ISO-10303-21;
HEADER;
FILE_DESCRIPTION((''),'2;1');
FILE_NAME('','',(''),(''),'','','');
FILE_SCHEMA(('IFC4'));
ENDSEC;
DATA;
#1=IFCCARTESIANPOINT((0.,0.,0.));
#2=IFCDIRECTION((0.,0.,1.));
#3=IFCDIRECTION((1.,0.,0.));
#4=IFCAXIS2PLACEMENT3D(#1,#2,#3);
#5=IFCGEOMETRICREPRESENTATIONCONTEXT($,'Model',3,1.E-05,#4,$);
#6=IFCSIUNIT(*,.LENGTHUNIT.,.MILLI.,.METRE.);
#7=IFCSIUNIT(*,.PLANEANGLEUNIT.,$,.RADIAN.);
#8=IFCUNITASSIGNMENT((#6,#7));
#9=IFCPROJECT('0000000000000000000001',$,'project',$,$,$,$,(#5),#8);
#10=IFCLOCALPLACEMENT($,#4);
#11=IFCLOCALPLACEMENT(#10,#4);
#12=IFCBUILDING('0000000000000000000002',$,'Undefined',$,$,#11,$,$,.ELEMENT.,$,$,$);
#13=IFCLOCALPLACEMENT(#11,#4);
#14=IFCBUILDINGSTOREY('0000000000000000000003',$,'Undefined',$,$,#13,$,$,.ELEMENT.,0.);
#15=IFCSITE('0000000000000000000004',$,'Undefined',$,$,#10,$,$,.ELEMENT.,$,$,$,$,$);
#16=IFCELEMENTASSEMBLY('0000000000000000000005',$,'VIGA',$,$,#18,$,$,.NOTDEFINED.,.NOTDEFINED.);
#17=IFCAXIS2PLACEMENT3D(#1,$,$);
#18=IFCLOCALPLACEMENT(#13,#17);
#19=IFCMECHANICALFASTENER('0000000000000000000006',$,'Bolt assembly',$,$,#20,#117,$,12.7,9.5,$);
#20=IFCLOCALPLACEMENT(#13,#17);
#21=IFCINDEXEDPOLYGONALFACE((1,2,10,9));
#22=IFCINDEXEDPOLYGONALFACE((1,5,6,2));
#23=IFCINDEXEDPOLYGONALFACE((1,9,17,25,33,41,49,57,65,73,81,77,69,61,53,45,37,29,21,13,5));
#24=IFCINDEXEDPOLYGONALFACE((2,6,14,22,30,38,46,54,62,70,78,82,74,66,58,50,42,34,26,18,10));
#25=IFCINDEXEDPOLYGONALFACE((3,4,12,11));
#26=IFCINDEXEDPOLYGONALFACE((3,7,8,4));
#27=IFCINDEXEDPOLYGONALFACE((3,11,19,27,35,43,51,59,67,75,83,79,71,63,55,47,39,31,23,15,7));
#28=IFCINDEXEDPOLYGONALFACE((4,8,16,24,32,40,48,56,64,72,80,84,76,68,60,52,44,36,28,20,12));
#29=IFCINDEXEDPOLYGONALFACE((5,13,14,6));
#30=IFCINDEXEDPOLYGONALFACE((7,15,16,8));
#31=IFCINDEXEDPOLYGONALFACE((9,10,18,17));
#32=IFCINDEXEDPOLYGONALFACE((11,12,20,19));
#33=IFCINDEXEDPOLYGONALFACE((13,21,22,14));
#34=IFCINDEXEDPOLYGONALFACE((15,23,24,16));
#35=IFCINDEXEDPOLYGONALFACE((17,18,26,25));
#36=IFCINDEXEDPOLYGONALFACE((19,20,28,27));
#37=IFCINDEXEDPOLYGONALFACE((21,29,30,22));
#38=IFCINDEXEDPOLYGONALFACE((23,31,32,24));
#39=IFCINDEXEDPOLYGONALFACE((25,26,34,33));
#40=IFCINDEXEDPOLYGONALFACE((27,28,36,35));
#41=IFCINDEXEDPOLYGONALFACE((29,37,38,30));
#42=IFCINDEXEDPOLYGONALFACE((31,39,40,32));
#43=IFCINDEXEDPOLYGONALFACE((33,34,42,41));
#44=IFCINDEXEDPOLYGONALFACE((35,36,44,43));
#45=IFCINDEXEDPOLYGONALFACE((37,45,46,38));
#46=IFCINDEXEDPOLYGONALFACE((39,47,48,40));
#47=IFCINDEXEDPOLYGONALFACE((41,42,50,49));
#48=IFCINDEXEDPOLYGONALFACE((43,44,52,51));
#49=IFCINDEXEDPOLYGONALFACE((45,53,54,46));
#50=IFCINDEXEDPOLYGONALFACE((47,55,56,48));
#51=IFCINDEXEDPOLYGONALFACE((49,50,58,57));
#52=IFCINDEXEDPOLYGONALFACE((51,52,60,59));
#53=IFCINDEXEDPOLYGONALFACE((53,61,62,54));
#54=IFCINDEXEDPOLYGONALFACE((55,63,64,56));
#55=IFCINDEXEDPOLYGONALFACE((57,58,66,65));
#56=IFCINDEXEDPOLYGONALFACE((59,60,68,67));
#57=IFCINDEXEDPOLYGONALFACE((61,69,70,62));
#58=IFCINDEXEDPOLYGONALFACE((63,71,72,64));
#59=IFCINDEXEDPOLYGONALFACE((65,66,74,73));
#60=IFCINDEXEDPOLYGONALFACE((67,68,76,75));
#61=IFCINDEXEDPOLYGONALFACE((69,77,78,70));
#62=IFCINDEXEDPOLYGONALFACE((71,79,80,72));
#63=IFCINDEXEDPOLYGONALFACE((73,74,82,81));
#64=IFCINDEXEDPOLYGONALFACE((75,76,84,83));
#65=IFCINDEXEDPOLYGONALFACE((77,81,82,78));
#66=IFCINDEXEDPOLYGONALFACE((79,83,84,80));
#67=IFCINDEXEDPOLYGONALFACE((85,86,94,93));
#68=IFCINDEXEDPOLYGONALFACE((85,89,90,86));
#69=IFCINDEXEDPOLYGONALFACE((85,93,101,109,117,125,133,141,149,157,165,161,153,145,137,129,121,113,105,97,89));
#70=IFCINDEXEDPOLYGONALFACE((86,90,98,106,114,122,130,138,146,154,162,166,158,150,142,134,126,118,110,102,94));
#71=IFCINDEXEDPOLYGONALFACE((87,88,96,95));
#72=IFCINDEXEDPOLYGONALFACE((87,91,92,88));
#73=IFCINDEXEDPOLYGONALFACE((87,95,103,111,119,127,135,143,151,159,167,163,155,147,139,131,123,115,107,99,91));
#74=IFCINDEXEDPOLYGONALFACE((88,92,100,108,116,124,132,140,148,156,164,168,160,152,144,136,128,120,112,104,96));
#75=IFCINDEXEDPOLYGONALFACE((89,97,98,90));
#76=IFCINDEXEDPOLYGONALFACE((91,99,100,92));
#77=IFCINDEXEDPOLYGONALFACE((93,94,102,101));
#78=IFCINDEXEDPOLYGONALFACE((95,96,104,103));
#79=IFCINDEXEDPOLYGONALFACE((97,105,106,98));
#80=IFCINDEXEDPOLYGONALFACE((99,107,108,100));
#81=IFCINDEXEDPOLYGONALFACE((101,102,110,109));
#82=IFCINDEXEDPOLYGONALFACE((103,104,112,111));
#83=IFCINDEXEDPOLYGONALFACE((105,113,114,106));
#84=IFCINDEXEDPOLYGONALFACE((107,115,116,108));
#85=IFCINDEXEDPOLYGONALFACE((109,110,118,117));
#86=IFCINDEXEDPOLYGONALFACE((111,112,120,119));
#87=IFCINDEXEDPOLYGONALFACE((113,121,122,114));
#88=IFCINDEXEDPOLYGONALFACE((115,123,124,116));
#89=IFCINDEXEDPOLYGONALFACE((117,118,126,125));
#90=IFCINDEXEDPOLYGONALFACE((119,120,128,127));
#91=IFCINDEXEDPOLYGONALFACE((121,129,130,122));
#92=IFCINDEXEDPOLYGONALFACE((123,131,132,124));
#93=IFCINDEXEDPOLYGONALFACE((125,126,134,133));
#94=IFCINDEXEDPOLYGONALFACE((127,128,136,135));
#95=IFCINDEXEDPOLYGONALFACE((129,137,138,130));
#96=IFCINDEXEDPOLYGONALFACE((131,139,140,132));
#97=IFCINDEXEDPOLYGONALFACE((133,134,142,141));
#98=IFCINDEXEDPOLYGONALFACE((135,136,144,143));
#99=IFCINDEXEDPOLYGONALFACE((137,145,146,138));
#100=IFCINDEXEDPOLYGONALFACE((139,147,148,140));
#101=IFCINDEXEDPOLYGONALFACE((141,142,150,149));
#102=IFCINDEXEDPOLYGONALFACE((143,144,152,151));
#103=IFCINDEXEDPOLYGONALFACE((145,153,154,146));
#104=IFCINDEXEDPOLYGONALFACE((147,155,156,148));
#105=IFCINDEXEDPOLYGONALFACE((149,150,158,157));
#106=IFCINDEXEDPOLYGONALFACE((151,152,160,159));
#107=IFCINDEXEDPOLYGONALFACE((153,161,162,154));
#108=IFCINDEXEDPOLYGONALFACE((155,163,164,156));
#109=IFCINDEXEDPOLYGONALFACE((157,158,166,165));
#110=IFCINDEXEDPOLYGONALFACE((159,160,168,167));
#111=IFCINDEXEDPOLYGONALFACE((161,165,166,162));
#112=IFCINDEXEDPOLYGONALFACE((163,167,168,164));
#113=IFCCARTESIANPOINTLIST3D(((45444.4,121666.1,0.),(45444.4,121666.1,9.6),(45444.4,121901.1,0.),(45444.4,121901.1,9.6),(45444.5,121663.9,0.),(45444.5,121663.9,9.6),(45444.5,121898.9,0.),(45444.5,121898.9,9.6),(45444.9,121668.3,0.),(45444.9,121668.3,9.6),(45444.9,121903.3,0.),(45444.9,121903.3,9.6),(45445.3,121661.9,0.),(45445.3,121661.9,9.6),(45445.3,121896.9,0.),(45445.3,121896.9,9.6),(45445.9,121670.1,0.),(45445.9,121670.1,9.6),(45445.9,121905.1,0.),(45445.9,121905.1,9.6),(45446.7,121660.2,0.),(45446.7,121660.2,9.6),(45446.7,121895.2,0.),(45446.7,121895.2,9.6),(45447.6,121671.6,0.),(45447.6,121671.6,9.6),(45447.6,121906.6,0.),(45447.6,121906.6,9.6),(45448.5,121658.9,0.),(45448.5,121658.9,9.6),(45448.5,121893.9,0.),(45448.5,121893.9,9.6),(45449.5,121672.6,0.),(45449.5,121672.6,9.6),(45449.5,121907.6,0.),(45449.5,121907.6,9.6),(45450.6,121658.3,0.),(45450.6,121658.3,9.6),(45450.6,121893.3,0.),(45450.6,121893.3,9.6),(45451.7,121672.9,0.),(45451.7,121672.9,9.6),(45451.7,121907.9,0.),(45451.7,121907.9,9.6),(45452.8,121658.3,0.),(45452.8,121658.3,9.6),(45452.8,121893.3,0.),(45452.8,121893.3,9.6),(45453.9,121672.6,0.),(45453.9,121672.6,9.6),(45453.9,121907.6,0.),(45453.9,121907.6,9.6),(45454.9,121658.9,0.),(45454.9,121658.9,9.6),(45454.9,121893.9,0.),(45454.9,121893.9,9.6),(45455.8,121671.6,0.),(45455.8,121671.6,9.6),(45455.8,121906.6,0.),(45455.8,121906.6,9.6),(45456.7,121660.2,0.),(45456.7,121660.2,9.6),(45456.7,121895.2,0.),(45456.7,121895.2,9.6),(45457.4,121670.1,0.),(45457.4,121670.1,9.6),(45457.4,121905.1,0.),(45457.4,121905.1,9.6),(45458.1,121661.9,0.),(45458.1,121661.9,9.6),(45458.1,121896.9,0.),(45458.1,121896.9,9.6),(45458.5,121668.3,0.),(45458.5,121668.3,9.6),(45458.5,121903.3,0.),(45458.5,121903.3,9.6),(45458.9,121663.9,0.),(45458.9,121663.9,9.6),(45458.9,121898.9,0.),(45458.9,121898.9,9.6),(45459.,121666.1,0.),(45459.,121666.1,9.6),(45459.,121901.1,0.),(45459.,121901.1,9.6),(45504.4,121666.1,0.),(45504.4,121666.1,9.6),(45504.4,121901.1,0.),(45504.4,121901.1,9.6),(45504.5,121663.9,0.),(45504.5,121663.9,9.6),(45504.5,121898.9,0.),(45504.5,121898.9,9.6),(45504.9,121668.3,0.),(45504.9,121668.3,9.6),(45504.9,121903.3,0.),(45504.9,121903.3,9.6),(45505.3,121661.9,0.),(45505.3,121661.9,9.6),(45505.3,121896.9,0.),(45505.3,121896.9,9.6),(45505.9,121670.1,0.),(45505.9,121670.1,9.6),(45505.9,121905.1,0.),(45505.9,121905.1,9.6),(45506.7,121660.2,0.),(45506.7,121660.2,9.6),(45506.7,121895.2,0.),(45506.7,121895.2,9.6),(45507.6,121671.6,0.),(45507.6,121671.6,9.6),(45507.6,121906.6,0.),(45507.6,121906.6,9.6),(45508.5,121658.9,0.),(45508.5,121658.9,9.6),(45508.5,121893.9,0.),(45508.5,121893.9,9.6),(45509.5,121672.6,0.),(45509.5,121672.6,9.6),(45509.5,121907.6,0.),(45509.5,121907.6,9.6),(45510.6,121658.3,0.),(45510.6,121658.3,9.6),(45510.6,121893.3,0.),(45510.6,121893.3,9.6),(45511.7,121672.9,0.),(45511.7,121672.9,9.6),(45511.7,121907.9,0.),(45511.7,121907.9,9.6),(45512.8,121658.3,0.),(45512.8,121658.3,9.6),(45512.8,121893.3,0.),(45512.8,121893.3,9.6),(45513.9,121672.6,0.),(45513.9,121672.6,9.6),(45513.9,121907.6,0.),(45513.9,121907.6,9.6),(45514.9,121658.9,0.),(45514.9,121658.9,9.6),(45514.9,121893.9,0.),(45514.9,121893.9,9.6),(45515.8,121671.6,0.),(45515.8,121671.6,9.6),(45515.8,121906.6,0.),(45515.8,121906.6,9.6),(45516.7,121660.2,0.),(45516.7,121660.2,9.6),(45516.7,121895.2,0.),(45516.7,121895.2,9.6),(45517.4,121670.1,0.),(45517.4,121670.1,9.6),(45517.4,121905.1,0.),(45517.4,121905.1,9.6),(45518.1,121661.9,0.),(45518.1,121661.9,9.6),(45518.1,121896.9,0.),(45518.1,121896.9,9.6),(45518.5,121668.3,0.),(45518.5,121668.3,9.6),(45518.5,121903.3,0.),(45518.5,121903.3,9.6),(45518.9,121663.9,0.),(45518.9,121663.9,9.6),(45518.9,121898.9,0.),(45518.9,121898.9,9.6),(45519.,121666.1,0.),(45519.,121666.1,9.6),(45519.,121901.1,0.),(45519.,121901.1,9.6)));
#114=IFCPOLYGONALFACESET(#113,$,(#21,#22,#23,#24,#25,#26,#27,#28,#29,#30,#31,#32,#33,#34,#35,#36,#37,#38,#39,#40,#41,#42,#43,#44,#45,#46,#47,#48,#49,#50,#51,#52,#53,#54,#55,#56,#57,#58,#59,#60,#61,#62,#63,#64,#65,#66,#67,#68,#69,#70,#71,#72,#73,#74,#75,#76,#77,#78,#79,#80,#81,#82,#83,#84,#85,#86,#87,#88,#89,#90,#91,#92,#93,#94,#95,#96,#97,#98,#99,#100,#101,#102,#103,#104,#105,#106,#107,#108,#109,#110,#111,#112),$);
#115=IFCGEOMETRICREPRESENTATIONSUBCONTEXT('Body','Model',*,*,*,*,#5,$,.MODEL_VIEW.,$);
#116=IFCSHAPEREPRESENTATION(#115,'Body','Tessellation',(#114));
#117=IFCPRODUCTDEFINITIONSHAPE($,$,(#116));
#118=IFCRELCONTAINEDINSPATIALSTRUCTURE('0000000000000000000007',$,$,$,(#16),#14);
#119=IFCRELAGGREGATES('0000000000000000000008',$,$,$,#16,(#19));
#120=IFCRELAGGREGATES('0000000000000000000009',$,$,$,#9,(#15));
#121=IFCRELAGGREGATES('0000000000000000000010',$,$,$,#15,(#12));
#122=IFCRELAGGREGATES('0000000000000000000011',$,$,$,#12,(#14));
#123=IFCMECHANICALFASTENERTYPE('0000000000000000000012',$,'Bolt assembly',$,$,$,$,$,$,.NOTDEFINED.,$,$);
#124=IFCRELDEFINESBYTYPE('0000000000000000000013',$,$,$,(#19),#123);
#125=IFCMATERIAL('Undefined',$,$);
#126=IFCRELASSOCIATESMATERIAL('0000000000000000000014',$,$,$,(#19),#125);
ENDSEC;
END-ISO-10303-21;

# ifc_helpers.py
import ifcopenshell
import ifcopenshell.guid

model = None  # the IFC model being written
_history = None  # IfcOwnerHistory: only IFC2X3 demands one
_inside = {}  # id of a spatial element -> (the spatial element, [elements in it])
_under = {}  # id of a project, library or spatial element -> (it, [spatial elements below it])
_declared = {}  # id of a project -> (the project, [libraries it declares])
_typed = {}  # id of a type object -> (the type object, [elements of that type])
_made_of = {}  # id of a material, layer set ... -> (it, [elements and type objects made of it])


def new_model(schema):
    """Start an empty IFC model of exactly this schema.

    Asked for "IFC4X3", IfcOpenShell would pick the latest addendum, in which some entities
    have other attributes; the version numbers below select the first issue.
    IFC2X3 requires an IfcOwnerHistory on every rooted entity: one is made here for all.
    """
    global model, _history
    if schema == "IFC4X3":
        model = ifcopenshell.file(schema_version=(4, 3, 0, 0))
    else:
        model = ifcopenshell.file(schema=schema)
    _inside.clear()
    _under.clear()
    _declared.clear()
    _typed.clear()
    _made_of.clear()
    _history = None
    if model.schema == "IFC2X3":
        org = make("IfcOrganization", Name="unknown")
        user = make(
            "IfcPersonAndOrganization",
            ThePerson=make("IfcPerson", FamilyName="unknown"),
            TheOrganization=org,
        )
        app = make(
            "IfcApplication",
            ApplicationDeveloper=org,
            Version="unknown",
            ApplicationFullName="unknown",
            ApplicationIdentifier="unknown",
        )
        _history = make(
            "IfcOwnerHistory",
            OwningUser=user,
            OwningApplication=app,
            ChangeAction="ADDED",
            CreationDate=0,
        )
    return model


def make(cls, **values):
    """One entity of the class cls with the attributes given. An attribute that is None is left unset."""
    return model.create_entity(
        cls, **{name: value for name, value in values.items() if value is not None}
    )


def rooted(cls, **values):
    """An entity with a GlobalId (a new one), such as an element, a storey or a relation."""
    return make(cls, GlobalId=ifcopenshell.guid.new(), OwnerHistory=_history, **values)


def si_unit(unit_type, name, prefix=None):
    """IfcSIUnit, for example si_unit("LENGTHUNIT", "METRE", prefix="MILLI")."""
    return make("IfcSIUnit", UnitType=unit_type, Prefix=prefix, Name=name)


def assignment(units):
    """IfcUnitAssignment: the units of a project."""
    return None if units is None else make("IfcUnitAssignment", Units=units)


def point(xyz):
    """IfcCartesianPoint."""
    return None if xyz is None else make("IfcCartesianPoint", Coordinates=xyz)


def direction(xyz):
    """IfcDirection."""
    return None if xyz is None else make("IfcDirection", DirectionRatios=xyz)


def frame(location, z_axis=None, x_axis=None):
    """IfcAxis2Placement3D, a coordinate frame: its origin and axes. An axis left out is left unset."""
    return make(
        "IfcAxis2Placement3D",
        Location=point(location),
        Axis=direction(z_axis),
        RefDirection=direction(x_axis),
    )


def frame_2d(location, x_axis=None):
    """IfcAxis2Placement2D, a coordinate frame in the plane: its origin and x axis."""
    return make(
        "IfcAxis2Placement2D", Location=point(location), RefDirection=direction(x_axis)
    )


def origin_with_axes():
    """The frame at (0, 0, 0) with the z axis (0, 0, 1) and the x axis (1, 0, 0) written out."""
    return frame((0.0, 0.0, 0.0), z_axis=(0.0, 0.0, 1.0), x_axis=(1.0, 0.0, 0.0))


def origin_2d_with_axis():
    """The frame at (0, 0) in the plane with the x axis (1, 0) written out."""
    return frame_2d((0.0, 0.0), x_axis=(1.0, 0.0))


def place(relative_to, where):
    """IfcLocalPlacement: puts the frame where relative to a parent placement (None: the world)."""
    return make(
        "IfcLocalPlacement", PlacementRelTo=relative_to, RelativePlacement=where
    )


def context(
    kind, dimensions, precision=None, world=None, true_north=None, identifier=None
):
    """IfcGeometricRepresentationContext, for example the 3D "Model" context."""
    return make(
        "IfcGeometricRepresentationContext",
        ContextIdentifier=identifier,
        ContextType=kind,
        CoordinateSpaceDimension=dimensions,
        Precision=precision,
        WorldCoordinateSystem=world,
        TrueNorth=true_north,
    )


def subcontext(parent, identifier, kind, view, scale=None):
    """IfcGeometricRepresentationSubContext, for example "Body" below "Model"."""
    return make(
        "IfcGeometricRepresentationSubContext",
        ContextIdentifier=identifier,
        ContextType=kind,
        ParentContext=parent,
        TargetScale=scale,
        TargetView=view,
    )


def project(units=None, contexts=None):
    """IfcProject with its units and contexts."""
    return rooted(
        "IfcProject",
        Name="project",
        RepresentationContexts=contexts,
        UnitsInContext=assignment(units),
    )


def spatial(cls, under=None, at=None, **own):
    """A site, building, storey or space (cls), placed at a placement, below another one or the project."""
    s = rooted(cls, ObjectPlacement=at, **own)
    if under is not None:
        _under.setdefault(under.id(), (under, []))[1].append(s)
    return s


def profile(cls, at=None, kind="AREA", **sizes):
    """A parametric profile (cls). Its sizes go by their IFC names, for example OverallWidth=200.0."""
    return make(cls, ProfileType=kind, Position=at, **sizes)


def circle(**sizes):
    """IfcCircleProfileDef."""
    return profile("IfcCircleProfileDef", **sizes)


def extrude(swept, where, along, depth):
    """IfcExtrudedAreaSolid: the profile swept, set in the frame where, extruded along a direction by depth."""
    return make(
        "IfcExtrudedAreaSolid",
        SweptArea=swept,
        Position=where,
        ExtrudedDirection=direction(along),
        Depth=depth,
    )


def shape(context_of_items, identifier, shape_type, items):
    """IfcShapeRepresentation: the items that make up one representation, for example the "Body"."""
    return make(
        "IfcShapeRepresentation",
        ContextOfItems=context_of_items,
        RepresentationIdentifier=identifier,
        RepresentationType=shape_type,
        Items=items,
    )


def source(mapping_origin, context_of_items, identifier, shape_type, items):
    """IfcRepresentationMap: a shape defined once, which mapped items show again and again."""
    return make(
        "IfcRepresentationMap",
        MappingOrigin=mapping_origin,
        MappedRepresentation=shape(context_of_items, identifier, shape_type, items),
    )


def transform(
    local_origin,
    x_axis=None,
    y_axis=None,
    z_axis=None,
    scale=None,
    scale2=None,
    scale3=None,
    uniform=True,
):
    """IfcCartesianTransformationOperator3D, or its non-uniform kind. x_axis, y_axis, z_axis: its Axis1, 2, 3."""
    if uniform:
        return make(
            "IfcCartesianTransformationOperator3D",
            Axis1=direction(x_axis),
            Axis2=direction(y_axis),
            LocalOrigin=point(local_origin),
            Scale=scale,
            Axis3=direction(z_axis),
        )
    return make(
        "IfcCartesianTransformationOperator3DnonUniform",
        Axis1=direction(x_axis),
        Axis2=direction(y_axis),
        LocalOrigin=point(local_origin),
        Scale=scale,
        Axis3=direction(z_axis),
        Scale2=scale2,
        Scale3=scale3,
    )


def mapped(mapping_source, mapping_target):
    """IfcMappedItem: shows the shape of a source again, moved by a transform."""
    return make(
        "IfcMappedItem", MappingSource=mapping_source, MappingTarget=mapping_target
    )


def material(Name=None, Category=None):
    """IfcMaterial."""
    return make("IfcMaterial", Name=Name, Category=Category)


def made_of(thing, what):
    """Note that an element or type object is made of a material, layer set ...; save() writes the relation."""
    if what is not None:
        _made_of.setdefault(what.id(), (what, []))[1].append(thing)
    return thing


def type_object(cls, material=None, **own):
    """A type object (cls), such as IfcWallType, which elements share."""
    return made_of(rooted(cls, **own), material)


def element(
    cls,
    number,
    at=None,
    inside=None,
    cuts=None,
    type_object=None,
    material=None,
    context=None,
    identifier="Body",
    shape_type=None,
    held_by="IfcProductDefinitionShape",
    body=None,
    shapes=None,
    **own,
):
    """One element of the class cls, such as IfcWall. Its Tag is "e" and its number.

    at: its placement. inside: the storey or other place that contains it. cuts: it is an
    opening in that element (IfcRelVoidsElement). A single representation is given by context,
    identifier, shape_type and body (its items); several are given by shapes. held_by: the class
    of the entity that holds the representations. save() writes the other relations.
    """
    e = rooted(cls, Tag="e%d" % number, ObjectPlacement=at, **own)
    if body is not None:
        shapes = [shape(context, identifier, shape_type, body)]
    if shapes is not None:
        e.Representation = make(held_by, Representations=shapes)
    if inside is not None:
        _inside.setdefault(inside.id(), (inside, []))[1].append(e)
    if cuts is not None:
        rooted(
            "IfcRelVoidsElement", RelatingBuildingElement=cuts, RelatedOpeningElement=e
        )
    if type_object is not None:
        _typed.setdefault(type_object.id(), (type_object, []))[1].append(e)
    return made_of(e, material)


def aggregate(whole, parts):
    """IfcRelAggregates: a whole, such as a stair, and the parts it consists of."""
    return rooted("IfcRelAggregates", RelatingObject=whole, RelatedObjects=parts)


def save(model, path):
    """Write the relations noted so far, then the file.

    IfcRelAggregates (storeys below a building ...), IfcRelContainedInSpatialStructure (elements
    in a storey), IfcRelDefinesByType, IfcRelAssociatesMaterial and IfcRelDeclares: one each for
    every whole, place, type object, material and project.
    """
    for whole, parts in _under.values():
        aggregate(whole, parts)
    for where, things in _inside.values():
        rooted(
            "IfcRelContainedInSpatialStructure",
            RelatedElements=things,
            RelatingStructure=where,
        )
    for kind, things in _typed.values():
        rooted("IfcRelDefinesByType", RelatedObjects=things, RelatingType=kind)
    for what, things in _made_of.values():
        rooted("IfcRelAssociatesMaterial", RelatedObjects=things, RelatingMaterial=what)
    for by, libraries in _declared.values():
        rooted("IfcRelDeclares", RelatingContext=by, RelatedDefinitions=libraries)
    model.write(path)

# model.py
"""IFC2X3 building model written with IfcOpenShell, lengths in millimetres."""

from ifc_helpers import new_model, si_unit, frame, origin_with_axes, origin_2d_with_axis, place, context, subcontext, project, spatial, circle, extrude, source, transform, mapped, material, type_object, element, aggregate, save


model = new_model("IFC2X3")

# Units and contexts
model_context = context("Model", 3, precision=1e-05, world=origin_with_axes())
body_context = subcontext(model_context, "Body", "Model", "MODEL_VIEW")
ifc_project = project(units=[si_unit("LENGTHUNIT", "METRE", prefix="MILLI"), si_unit("PLANEANGLEUNIT", "RADIAN")], contexts=[model_context])

# Site, building, storey
site_placement = place(None, origin_with_axes())
site = spatial("IfcSite", under=ifc_project, at=site_placement, Name="Undefined", CompositionType="ELEMENT")
building_placement = place(site_placement, origin_with_axes())
building = spatial("IfcBuilding", under=site, at=building_placement, Name="Undefined", CompositionType="ELEMENT")
storey_placement = place(building_placement, origin_with_axes())
storey = spatial("IfcBuildingStorey", under=building, at=storey_placement, Name="Undefined", CompositionType="ELEMENT", Elevation=0.0)

# Element assembly
assembly_1_placement = place(storey_placement, origin_with_axes())
assembly_1 = element("IfcElementAssembly", 1, at=assembly_1_placement, inside=storey, Name="VIGA", AssemblyPlace="NOTDEFINED", PredefinedType="NOTDEFINED")

# Shared definitions
ifc_material_1 = material(Name="Undefined")
mechanical_fastener_type = type_object("IfcMechanicalFastenerType", Name="Bolt assembly")

# Mechanical fastener
shared_shape_1 = source(origin_with_axes(), body_context, "Body", "SweptSolid", [
    extrude(circle(Radius=7.3, at=origin_2d_with_axis()), frame((0.0, -9.5, 0.0), z_axis=(0.0, 1.0, 0.0), x_axis=(1.0, 0.0, 0.0)), (0.0, 0.0, 1.0), 9.6),
])
mechanical_fastener_1_placement = place(assembly_1_placement, frame((45481.7, 121665.6, 9.5), z_axis=(1.0, 0.0, 0.0), x_axis=(0.0, 1.0, 0.0)))
mechanical_fastener_1 = element("IfcMechanicalFastener", 2, at=mechanical_fastener_1_placement, type_object=mechanical_fastener_type, material=ifc_material_1, Name="Bolt assembly", NominalDiameter=12.7, NominalLength=9.5, context=body_context, shape_type="MappedRepresentation", body=[
    mapped(shared_shape_1, transform((0.0, 0.0, -30.0))),
    mapped(shared_shape_1, transform((235.0, 0.0, -30.0))),
    mapped(shared_shape_1, transform((0.0, 0.0, 30.0))),
    mapped(shared_shape_1, transform((235.0, 0.0, 30.0))),
])
aggregate(assembly_1, [mechanical_fastener_1])

save(model, "model.ifc")
